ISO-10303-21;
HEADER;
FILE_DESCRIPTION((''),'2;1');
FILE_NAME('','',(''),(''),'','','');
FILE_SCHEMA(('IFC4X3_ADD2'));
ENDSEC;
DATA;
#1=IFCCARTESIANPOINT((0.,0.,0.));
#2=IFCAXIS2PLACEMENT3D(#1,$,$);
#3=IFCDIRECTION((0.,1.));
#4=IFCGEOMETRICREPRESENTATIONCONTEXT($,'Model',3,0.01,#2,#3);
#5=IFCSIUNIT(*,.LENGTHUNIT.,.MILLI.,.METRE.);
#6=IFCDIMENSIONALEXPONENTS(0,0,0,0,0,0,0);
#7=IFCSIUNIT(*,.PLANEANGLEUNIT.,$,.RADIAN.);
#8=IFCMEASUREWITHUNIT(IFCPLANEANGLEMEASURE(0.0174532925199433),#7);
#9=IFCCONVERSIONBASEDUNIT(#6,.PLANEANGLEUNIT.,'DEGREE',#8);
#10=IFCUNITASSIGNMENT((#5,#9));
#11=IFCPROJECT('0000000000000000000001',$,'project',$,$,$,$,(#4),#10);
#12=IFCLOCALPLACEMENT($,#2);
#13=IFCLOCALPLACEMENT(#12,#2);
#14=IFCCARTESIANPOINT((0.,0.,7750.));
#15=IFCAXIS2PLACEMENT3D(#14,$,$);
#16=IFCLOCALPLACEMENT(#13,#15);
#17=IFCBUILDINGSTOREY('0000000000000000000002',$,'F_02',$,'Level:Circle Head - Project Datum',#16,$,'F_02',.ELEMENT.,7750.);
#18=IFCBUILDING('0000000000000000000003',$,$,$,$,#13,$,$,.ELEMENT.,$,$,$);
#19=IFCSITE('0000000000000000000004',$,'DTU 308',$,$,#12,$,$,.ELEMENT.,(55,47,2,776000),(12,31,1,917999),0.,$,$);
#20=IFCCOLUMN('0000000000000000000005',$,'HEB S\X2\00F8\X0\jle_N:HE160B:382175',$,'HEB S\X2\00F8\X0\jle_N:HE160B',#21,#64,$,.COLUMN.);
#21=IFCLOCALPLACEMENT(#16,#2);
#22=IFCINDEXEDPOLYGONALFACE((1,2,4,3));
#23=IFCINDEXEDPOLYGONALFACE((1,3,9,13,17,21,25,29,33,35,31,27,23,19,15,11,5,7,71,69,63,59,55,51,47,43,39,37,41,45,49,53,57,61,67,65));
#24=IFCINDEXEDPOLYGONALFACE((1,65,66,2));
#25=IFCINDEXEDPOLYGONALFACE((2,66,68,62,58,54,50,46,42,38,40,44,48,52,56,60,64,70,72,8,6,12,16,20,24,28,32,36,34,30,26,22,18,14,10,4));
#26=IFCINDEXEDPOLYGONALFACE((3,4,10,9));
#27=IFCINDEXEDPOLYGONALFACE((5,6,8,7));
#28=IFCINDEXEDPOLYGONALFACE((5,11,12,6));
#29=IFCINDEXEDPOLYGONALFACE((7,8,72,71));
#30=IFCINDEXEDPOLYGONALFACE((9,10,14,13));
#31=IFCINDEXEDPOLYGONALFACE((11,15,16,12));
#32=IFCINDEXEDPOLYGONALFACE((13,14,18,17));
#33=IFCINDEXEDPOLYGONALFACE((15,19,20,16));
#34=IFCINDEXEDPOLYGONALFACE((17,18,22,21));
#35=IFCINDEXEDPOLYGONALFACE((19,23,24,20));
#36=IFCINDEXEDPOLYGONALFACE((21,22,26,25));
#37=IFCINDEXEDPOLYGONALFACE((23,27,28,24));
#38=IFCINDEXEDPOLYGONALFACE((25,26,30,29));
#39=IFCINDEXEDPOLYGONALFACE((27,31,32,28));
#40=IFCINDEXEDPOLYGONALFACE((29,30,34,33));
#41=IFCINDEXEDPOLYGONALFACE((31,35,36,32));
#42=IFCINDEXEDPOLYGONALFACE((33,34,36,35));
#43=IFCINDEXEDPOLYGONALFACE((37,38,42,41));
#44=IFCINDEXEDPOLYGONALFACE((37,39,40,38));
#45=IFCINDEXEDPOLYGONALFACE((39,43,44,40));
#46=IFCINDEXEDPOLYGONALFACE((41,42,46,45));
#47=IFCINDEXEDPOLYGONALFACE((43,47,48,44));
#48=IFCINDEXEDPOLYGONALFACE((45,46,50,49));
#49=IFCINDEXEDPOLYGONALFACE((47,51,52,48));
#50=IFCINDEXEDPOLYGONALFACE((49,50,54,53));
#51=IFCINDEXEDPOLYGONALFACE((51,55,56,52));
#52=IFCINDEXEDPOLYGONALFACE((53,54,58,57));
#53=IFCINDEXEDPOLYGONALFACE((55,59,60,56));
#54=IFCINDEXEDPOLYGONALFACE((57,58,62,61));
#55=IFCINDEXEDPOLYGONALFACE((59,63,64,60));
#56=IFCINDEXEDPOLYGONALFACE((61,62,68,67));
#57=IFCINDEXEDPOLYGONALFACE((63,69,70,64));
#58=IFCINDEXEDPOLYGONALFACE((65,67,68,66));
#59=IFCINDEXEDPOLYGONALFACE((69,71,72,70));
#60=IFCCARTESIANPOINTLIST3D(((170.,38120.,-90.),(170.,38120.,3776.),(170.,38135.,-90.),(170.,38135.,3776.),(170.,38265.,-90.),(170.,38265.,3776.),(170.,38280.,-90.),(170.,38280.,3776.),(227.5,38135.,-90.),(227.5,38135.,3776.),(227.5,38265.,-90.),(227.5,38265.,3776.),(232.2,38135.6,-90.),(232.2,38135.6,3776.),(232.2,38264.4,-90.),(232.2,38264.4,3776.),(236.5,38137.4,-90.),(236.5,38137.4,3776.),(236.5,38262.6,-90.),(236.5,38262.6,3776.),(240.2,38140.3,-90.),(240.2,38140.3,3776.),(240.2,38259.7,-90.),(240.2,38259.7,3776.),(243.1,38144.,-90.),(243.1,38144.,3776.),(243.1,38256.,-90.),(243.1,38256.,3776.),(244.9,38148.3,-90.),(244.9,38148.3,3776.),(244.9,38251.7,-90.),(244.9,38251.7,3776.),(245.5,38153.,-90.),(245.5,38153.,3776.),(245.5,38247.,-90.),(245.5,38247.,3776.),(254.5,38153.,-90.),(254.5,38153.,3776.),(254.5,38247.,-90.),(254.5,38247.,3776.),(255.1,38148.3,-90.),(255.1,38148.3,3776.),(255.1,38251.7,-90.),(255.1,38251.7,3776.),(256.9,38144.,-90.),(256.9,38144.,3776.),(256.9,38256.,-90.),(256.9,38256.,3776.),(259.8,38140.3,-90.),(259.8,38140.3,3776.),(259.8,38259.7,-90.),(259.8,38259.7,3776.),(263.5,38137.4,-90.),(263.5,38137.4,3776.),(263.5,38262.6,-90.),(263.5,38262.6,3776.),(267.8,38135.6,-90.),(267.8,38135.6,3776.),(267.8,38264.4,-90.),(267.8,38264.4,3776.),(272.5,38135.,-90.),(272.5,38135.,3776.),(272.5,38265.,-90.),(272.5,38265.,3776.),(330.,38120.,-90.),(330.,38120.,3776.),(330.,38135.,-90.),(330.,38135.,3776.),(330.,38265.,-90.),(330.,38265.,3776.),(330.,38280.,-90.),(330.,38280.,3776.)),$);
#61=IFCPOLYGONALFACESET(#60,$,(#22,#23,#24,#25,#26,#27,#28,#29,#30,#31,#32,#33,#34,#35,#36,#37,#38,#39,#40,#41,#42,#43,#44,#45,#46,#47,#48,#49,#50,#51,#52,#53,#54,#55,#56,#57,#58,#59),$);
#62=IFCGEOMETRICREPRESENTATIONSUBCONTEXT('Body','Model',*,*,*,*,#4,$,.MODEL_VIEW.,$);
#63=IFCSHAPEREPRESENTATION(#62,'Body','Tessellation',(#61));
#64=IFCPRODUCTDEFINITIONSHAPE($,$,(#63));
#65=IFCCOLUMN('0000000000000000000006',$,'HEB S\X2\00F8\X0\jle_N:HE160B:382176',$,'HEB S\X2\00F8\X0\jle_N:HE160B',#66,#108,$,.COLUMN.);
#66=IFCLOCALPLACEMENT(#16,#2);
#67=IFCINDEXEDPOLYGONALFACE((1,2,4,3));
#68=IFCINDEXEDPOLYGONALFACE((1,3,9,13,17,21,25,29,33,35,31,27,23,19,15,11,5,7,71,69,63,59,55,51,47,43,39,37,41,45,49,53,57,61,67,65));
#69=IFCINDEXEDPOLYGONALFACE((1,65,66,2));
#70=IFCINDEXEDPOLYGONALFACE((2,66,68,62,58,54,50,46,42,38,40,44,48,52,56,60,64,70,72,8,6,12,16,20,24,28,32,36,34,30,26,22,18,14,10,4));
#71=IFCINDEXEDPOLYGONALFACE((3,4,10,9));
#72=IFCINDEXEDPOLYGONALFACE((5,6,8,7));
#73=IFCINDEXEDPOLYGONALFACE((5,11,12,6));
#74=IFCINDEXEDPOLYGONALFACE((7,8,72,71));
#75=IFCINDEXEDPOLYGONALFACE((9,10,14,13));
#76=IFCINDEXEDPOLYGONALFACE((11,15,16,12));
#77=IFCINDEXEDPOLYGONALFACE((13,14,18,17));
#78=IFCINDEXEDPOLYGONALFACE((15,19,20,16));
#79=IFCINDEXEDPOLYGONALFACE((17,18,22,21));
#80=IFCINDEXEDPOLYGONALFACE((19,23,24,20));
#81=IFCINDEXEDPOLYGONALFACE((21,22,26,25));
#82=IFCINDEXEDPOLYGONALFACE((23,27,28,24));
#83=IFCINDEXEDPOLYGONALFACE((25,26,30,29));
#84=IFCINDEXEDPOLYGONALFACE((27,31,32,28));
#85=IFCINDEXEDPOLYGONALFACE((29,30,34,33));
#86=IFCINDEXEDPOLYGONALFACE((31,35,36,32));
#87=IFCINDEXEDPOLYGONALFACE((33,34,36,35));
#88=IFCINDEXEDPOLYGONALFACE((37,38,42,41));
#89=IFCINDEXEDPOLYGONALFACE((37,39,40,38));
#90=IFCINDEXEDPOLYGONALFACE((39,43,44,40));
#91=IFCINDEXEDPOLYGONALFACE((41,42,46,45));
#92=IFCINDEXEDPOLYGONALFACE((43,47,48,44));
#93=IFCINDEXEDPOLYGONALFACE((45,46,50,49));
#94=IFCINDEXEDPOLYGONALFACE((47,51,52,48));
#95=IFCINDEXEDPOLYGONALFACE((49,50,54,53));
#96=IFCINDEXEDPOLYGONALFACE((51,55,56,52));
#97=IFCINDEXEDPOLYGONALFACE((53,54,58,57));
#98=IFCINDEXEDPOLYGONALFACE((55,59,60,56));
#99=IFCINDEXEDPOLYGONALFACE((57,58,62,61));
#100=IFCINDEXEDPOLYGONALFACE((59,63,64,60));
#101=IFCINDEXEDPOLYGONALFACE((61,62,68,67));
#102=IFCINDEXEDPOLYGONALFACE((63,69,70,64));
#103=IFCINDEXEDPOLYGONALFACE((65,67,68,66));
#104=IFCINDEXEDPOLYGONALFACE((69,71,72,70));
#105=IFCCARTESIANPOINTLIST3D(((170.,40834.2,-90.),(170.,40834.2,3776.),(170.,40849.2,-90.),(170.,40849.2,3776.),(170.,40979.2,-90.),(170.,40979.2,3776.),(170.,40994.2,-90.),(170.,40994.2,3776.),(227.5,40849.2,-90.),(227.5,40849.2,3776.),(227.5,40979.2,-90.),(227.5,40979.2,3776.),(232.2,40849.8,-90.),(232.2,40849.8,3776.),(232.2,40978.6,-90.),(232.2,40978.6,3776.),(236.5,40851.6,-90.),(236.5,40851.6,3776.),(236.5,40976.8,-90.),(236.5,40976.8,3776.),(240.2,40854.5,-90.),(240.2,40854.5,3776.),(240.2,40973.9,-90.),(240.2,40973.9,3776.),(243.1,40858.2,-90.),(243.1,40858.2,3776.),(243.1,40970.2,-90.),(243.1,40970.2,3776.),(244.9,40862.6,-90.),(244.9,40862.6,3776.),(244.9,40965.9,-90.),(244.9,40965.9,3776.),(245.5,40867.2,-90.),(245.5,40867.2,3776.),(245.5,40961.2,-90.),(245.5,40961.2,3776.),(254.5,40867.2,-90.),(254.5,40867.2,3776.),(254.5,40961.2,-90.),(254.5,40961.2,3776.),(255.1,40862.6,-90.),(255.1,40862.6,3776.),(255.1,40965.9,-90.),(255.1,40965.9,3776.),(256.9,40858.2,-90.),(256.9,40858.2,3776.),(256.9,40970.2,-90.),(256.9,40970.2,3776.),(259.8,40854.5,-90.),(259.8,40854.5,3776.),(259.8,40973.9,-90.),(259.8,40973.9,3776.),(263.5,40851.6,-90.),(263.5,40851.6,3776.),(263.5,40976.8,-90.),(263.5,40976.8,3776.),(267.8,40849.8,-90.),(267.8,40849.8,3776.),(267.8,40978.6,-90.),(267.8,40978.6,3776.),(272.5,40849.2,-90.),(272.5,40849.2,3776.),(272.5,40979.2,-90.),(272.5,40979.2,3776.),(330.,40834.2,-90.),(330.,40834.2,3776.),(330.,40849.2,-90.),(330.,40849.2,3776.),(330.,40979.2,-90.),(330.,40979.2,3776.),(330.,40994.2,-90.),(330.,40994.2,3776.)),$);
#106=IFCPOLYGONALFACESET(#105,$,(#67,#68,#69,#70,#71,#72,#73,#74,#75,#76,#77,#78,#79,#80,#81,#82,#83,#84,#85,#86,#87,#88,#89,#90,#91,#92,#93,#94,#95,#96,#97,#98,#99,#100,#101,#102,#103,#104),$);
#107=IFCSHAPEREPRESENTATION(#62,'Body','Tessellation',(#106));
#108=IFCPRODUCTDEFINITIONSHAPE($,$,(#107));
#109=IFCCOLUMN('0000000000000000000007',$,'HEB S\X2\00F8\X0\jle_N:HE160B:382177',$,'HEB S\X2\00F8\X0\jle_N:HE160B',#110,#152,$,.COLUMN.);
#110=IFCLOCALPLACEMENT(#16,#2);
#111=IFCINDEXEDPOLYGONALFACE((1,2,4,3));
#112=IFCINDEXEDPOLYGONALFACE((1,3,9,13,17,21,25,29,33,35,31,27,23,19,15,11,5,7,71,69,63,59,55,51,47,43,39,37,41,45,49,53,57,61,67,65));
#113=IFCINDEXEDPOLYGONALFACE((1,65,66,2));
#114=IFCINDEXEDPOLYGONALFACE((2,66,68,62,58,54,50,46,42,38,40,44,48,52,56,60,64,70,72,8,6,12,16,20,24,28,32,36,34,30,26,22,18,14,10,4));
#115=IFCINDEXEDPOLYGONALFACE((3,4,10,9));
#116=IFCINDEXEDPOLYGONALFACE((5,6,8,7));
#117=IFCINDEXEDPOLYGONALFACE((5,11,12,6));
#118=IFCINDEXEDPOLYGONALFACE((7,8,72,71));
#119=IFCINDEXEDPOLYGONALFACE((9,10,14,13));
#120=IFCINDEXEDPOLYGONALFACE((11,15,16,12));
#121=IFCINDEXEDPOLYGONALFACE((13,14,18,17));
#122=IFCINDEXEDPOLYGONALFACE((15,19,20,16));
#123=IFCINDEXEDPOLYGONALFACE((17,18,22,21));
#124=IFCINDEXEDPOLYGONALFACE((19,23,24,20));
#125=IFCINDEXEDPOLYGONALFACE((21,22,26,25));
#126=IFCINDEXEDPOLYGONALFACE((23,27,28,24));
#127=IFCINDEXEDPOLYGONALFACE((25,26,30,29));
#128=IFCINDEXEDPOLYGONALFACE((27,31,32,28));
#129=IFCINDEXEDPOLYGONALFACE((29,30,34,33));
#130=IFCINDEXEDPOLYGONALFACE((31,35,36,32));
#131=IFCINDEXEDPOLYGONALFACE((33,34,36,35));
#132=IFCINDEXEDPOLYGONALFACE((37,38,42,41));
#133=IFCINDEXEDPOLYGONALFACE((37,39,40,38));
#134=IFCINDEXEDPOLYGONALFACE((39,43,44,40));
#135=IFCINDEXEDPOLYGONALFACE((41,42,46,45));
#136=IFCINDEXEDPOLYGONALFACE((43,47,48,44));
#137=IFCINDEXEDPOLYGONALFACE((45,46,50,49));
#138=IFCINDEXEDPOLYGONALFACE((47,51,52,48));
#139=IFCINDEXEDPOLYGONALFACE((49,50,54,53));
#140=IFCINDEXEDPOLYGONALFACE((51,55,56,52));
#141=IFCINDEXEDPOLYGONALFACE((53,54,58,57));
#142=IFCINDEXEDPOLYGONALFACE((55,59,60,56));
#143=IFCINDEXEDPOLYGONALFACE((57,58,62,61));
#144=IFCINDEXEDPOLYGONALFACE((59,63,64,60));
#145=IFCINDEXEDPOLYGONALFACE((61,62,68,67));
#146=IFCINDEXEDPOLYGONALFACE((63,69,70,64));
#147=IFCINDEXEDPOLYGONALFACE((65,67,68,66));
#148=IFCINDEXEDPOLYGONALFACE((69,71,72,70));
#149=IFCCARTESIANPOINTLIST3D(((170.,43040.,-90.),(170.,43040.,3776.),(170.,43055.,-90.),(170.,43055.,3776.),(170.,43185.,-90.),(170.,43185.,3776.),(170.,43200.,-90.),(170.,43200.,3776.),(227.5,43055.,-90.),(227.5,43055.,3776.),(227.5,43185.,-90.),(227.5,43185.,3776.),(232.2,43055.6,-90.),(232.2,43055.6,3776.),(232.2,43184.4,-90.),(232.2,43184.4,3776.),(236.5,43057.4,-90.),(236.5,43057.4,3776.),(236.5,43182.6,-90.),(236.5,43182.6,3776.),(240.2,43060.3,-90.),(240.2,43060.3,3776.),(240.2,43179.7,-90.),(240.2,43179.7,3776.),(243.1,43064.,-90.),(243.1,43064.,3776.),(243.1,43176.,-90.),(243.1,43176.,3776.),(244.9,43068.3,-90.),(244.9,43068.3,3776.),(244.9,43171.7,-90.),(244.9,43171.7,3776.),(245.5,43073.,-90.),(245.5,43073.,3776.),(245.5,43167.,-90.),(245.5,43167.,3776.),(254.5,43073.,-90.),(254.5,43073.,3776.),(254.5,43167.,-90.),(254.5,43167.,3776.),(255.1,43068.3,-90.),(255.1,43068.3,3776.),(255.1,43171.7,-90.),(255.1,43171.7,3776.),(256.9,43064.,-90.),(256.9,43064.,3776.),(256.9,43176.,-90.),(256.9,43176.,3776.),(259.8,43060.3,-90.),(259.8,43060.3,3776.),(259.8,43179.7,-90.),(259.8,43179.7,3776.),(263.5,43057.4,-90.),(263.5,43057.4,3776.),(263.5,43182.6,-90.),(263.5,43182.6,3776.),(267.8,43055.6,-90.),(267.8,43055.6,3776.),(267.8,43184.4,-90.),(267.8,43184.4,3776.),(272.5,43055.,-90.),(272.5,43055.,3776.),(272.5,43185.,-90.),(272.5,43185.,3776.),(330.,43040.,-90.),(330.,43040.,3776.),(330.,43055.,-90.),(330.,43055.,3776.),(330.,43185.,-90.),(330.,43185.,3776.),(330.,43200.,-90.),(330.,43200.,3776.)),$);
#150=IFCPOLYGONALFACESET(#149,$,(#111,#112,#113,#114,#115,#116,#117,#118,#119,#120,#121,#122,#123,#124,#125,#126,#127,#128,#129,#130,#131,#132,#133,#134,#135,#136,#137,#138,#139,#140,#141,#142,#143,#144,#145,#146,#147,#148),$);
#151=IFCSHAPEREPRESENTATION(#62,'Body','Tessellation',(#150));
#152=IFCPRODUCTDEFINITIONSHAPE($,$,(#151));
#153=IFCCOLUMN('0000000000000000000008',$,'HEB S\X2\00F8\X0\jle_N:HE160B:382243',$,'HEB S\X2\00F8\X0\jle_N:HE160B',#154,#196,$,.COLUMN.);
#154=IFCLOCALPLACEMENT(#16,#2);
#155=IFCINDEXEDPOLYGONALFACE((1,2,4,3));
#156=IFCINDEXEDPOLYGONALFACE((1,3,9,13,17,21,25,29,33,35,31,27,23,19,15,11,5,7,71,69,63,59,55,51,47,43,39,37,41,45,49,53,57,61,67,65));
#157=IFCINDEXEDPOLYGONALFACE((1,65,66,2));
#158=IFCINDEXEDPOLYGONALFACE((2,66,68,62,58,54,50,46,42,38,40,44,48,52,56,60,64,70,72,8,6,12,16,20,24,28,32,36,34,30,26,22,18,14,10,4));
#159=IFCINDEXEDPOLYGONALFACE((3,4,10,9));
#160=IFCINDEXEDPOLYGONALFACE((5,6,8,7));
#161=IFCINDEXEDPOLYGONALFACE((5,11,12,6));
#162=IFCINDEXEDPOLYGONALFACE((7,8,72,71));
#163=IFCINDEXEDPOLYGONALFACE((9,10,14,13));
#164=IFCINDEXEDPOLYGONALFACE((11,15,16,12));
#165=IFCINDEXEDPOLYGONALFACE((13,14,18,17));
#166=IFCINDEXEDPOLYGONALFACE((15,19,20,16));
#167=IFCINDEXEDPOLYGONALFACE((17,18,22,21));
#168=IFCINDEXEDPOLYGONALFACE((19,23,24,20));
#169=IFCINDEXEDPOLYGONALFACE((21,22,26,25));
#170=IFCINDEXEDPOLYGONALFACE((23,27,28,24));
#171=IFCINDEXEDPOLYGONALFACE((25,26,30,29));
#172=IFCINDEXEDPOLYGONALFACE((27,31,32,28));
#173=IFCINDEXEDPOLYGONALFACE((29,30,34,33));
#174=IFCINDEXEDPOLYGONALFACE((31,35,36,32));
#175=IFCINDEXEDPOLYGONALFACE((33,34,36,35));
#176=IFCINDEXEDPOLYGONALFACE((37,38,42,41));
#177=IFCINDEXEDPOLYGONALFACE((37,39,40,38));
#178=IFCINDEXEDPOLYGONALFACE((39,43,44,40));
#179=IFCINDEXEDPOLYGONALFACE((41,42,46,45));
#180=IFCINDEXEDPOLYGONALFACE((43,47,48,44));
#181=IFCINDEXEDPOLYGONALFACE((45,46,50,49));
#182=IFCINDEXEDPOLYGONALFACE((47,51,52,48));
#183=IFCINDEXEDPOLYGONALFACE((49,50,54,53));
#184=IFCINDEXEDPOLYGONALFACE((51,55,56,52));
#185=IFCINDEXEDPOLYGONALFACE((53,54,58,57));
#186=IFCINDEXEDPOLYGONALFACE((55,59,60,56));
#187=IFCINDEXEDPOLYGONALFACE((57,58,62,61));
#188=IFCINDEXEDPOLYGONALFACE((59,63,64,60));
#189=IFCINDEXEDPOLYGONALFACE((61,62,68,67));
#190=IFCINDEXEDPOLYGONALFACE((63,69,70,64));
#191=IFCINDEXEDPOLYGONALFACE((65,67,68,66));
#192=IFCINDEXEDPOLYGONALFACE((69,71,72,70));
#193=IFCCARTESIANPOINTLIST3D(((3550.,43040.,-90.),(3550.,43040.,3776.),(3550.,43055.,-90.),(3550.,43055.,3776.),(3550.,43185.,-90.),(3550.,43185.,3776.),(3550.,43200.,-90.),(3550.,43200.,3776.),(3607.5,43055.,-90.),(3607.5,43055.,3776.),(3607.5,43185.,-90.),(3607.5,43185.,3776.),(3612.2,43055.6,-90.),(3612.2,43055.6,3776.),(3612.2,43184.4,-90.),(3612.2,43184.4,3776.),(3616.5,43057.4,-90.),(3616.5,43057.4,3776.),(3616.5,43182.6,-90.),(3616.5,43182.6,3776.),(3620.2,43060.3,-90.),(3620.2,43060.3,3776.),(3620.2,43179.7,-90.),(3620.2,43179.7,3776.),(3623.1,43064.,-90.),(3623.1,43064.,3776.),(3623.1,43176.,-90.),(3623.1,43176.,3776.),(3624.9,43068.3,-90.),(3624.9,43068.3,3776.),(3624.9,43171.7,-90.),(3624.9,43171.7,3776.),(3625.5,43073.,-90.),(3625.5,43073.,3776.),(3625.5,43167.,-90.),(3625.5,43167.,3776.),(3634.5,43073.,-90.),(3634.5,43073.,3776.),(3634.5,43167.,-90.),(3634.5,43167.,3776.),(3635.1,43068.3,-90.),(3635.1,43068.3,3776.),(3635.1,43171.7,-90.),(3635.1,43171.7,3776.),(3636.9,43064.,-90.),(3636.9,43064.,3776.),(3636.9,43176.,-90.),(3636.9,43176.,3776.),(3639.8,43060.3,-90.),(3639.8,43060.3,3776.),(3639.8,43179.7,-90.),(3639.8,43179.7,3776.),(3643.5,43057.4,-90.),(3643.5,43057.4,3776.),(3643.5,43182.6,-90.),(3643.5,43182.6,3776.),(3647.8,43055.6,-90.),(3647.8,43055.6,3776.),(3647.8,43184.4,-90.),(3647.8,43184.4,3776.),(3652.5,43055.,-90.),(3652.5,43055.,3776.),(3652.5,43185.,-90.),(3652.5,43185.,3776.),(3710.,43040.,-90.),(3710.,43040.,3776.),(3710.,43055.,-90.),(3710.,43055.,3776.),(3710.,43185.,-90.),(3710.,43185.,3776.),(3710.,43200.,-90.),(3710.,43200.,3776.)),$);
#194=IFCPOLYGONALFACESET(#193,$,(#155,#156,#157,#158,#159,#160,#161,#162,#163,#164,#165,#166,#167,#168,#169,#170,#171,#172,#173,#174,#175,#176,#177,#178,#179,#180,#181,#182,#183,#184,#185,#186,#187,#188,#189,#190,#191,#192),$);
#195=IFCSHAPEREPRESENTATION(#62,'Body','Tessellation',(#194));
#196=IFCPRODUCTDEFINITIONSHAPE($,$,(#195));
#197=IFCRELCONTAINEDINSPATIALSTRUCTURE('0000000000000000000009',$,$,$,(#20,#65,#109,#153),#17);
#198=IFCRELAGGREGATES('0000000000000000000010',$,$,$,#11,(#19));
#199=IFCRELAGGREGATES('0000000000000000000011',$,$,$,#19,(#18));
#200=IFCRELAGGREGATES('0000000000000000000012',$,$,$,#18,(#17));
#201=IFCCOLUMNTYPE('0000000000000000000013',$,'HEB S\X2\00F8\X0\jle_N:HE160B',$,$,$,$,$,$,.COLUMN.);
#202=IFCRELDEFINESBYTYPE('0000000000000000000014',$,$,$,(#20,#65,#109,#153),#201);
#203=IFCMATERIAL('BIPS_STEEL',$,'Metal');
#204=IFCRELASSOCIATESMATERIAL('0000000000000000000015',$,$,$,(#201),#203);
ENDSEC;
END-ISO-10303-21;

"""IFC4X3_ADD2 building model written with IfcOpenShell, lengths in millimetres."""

from ifc_helpers import new_model, entity, si_unit, converted_unit, direction, frame, frame_2d, origin, place, context, subcontext, project, spatial, i_section, extrude, source, transform, mapped, material, material_profile, profile_set, type_object, element, save


model = new_model("IFC4X3_ADD2")

# Units and contexts
model_context = context("Model", 3, precision=0.01, world=origin(), true_north=direction((0.0, 1.0)))
body_context = subcontext(model_context, "Body", "Model", "MODEL_VIEW")
ifc_project = project(units=[si_unit("LENGTHUNIT", "METRE", prefix="MILLI"), converted_unit("PLANEANGLEUNIT", "DEGREE", entity("IfcPlaneAngleMeasure", 0.0174532925199433), si_unit("PLANEANGLEUNIT", "RADIAN"), dimensions=[0, 0, 0, 0, 0, 0, 0])], contexts=[model_context])

# Site, building, storey
site_placement = place(None, origin())
site = spatial("IfcSite", under=ifc_project, at=site_placement, Name="DTU 308", CompositionType="ELEMENT", RefLatitude=(55, 47, 2, 776000), RefLongitude=(12, 31, 1, 917999), RefElevation=0.0)
building_placement = place(site_placement, origin())
building = spatial("IfcBuilding", under=site, at=building_placement, CompositionType="ELEMENT")
storey_placement = place(building_placement, frame((0.0, 0.0, 7750.0)))
storey = spatial("IfcBuildingStorey", under=building, at=storey_placement, Name="F_02", ObjectType="Level:Circle Head - Project Datum", LongName="F_02", CompositionType="ELEMENT", Elevation=7750.0)

# Columns
ifc_material = material(Name="BIPS_STEEL", Category="Metal")
ifc_material_profile_1 = material_profile(ifc_material, i_section(OverallWidth=160.0, OverallDepth=160.0, WebThickness=9.0, FlangeThickness=15.0, FilletRadius=18.0, at=frame_2d((0.0, 0.0), x_axis=(1.0, 0.0))), Name="HE160B")
ifc_profile_set_1 = profile_set([ifc_material_profile_1], Name="HE160B")
column_type_1 = type_object("IfcColumnType", Name="HEB Søjle_N:HE160B", PredefinedType="COLUMN", material=ifc_profile_set_1)
shared_shape_1 = source(origin(), body_context, "Body", "SweptSolid", [
    extrude(i_section(OverallWidth=160.0, OverallDepth=160.0, WebThickness=9.0, FlangeThickness=15.0, FilletRadius=18.0, at=frame_2d((0.0, 0.0), x_axis=(1.0, 0.0))), frame((0.0, 0.0, 7660.0), z_axis=(0.0, 0.0, 1.0), x_axis=(-1.0, 0.0, 0.0)), (0.0, 0.0, 1.0), 3866.0),
])
for number, where, name in (
    (1, (250.0, 38200.0, -7750.0), "HEB Søjle_N:HE160B:382175"),
    (2, (250.0, 40914.2, -7750.0), "HEB Søjle_N:HE160B:382176"),
    (3, (250.0, 43120.0, -7750.0), "HEB Søjle_N:HE160B:382177"),
    (4, (3630.0, 43120.0, -7750.0), "HEB Søjle_N:HE160B:382243"),
):
    element("IfcColumn", number, at=place(storey_placement, frame(where)), inside=storey, type_object=column_type_1, Name=name, ObjectType="HEB Søjle_N:HE160B", PredefinedType="COLUMN", context=body_context, shape_type="MappedRepresentation", body=[
        mapped(shared_shape_1, transform((0.0, 0.0, 0.0), scale=1.0)),
    ])

save(model, "model.ifc")
